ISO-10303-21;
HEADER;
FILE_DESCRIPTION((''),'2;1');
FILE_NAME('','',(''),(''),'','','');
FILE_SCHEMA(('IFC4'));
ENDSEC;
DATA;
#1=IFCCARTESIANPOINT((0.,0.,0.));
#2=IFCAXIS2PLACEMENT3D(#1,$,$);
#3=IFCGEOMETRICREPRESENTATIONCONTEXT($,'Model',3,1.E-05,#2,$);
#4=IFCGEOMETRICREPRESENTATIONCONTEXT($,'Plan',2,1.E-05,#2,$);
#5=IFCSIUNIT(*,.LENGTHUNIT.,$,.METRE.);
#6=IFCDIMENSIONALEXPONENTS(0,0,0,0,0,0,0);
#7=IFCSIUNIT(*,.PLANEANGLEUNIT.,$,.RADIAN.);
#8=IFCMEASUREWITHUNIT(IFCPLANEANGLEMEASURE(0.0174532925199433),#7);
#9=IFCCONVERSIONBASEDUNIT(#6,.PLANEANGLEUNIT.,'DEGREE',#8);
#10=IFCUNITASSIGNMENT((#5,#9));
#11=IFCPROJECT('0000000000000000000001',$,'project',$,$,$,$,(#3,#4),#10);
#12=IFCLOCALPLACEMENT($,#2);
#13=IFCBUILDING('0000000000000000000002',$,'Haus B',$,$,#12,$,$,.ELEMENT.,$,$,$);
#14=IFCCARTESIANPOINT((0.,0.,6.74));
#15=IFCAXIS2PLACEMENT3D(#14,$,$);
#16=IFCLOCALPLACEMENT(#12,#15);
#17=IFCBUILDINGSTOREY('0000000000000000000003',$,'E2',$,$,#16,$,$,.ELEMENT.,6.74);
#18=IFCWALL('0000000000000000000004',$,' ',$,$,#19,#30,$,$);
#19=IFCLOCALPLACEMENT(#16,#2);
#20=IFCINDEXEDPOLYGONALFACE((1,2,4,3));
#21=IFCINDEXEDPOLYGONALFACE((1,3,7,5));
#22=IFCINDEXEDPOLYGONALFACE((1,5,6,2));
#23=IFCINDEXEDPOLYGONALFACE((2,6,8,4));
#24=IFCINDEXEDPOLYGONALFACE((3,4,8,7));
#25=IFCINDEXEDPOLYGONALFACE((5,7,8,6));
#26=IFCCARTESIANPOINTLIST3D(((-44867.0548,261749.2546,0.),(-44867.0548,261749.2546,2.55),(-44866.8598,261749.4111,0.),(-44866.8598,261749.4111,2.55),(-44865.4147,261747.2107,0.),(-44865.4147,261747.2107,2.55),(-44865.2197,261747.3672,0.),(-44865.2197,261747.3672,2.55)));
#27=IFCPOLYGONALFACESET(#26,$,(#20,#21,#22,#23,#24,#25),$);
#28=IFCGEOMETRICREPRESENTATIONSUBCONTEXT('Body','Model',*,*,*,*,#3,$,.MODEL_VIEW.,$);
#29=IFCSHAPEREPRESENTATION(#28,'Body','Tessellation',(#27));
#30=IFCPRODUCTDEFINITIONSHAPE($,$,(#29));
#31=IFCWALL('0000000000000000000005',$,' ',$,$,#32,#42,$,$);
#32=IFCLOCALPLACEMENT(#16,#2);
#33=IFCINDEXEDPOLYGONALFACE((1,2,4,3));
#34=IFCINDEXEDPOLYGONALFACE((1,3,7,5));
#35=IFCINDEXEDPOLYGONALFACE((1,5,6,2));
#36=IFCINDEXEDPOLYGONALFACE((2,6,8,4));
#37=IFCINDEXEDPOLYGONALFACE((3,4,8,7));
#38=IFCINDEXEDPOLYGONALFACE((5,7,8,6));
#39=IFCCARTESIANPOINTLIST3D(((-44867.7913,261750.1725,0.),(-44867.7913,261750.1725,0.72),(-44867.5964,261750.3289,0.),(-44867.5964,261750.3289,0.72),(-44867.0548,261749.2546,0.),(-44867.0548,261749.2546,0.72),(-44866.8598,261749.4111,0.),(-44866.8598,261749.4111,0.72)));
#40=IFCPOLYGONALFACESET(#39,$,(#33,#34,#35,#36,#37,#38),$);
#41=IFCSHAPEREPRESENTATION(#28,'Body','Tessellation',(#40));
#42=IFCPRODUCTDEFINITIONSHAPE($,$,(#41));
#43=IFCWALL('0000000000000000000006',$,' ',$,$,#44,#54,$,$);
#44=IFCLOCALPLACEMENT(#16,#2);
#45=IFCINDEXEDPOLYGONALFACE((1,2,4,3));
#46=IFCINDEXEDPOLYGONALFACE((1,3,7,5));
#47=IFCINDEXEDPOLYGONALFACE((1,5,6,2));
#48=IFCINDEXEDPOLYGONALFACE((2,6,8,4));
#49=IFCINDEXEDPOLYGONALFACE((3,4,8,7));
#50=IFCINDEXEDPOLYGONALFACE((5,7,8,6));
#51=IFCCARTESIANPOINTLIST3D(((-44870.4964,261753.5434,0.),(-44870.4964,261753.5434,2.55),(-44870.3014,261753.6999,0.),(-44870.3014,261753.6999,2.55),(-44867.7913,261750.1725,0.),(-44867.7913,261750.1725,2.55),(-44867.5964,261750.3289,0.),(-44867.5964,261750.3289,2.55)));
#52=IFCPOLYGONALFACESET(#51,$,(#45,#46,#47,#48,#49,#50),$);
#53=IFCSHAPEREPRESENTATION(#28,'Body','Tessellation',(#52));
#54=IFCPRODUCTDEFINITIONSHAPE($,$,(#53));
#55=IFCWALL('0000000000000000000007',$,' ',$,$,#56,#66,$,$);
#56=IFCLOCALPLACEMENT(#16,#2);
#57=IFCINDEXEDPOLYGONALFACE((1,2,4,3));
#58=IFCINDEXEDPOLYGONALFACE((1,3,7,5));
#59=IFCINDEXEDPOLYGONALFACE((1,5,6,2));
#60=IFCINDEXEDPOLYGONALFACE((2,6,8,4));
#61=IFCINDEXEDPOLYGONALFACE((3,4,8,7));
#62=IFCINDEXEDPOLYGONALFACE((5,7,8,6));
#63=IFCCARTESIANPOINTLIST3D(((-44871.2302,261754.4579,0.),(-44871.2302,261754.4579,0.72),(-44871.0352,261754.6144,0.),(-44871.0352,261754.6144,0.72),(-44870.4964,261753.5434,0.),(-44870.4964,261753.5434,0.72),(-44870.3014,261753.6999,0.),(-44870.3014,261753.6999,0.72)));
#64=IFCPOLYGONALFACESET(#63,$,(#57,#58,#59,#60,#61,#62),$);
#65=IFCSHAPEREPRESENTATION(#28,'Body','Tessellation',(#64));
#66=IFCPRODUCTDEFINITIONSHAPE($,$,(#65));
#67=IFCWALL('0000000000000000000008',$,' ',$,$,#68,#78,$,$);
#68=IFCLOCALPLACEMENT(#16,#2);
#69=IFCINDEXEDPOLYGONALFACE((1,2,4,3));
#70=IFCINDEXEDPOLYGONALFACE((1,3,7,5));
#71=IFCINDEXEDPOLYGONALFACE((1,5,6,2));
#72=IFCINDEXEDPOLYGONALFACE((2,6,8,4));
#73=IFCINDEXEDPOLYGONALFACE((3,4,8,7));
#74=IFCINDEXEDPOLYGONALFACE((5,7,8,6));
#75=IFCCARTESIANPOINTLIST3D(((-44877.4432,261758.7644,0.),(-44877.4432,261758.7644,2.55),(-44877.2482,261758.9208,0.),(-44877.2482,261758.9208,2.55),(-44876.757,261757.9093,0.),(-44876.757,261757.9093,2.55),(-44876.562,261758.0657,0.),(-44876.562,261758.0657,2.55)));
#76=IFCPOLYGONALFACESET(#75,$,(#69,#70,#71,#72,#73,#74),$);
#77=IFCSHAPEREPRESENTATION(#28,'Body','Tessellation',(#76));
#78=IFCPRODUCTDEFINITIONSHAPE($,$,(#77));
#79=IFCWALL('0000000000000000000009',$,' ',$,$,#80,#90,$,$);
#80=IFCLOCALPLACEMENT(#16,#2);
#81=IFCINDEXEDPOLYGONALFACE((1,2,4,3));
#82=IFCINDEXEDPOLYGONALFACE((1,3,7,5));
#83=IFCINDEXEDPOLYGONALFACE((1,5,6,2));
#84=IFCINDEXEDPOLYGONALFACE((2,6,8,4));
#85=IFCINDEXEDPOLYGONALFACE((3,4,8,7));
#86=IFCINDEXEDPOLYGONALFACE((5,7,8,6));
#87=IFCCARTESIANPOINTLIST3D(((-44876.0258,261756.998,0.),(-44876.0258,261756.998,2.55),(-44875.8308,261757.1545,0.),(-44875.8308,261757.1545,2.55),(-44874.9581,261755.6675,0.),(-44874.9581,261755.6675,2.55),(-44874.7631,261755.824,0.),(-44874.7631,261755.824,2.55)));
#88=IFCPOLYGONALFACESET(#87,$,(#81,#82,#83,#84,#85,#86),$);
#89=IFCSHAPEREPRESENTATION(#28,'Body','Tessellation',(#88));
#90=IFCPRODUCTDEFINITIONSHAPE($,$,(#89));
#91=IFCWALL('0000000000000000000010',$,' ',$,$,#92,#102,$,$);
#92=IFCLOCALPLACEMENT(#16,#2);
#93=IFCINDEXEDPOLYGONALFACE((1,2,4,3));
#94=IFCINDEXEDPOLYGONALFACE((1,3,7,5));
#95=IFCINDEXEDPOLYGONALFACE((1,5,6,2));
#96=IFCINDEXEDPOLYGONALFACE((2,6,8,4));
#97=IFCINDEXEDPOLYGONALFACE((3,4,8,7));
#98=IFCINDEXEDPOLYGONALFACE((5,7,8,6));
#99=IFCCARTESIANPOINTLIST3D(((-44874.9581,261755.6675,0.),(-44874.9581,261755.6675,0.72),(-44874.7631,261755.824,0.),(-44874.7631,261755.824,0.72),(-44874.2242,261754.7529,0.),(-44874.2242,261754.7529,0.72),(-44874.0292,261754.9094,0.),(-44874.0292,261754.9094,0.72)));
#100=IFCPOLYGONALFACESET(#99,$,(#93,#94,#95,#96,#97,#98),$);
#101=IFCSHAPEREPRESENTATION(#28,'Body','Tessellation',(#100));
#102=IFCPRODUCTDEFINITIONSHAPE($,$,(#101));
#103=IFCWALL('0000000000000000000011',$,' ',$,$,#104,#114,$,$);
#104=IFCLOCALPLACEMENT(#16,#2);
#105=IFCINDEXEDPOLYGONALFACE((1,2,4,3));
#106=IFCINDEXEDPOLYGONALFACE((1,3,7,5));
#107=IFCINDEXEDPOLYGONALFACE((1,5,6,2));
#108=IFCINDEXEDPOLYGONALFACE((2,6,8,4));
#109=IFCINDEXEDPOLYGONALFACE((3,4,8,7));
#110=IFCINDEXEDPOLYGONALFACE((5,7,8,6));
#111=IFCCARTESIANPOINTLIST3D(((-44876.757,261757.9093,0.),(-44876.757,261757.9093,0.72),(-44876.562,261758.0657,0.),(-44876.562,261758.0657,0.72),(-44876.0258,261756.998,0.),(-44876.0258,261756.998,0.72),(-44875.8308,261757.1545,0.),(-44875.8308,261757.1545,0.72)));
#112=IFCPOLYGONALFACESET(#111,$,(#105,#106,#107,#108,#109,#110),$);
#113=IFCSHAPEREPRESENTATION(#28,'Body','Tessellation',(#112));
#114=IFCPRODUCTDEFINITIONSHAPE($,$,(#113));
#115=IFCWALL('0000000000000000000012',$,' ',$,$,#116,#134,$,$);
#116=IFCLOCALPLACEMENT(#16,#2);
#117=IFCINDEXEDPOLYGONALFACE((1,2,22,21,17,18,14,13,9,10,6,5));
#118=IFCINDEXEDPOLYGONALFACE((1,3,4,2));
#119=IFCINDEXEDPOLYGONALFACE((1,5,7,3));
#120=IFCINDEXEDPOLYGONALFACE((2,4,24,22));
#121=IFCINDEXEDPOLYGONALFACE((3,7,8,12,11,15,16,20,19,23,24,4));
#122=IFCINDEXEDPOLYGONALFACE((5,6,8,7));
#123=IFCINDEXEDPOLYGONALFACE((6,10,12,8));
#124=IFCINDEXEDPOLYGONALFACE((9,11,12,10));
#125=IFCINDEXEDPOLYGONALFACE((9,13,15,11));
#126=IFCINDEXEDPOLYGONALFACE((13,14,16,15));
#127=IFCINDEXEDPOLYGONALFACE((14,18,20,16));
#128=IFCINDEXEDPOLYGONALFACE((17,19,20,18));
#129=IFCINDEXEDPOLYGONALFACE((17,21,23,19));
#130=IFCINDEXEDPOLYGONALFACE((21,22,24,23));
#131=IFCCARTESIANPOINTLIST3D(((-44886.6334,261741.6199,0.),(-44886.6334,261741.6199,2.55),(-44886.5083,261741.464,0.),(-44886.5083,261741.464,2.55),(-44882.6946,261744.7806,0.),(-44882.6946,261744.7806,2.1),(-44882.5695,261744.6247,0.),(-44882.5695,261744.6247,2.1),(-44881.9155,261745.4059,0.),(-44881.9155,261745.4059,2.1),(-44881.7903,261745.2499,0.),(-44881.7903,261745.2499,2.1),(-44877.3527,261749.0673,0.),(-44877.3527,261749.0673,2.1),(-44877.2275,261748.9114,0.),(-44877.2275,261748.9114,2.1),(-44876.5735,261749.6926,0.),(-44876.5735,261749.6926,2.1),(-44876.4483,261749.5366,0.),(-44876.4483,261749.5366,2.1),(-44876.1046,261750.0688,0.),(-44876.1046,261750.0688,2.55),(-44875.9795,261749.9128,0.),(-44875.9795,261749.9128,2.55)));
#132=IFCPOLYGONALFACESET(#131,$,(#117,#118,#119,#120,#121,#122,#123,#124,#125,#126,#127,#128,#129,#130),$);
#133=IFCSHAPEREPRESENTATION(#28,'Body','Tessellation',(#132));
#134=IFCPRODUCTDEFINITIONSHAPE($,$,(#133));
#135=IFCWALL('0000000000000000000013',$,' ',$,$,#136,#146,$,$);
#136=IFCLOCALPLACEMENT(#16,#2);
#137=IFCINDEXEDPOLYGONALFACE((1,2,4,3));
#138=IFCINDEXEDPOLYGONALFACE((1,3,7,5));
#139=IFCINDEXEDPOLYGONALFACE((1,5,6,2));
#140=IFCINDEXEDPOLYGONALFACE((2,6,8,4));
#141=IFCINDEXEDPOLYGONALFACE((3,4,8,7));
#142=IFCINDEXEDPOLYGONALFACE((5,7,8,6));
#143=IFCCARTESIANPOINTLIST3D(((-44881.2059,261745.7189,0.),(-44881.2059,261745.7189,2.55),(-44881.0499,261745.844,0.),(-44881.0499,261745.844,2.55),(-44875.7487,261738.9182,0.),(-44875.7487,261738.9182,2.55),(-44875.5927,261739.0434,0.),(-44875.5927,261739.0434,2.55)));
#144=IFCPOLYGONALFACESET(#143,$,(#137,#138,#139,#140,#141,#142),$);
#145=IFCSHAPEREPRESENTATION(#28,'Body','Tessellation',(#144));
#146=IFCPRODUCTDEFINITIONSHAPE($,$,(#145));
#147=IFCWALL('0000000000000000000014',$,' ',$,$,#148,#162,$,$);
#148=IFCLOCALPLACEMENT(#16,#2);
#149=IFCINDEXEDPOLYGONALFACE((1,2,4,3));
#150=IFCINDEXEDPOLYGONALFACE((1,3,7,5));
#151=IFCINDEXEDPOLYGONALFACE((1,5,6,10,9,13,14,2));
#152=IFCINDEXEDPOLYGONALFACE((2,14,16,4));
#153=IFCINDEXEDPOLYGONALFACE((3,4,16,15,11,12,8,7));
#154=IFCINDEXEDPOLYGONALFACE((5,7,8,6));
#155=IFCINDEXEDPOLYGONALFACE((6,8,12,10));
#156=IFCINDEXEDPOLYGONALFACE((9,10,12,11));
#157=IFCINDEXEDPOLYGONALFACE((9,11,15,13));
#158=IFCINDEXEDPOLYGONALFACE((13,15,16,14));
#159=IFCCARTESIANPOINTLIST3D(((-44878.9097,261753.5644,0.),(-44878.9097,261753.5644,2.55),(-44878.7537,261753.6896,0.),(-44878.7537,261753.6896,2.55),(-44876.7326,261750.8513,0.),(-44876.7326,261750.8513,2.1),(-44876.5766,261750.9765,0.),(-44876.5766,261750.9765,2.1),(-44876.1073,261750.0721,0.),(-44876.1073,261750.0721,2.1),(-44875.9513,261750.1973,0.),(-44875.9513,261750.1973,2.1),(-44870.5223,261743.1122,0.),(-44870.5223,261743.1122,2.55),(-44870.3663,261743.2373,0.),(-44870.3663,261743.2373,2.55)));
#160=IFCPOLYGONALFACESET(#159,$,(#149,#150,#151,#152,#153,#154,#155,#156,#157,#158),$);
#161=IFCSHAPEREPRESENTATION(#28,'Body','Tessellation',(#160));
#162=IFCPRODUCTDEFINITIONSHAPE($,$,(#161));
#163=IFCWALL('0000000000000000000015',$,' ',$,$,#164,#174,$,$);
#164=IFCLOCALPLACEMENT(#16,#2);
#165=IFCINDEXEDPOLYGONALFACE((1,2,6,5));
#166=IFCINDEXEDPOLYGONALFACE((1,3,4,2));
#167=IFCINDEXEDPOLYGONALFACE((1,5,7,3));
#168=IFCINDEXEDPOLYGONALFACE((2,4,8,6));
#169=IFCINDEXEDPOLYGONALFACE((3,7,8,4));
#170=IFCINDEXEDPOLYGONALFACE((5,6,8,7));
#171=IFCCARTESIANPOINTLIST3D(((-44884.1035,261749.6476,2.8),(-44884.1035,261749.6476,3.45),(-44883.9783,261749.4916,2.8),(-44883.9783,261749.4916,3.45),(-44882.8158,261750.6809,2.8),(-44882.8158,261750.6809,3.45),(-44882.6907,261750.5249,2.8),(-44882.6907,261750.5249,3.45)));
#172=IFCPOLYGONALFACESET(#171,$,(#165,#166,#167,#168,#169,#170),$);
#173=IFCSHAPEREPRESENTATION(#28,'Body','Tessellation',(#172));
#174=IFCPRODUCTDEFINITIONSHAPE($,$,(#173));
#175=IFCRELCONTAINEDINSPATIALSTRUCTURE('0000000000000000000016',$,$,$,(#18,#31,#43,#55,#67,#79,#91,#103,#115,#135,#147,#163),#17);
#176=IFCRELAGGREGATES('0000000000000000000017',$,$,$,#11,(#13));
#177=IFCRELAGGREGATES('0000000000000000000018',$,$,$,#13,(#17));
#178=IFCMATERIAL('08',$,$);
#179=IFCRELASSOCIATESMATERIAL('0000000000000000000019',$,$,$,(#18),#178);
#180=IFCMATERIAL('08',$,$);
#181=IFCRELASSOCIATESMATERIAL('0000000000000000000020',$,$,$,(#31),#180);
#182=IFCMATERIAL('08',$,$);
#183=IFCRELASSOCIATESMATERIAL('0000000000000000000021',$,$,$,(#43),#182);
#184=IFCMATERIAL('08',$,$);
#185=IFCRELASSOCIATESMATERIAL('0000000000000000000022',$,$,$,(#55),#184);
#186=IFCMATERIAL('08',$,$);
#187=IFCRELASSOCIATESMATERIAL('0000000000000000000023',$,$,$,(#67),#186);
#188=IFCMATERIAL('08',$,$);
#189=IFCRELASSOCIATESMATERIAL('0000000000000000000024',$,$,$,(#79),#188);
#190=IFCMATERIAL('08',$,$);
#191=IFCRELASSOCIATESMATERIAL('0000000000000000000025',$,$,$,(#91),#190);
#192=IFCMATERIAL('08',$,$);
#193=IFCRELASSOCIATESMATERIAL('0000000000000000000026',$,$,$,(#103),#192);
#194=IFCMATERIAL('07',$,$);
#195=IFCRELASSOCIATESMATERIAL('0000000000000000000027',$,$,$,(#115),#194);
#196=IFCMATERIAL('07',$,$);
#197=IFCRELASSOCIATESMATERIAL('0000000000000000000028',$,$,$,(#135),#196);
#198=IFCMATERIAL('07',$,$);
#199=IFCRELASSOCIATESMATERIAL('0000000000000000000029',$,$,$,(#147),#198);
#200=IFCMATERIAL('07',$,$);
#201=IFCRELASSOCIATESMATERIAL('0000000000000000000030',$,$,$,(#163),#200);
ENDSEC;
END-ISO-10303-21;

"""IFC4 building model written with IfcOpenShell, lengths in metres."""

from ifc_helpers import new_model, entity, si_unit, converted_unit, frame, frame_2d, origin, origin_with_axes, place, context, subcontext, project, spatial, polyline, rectangle, outline, extrude, material, element, save


model = new_model("IFC4")

# Units and contexts
model_context = context("Model", 3, precision=1e-05, world=origin())
plan_context = context("Plan", 2, precision=1e-05, world=origin())
body_context = subcontext(model_context, "Body", "Model", "MODEL_VIEW")
ifc_project = project(units=[si_unit("LENGTHUNIT", "METRE"), converted_unit("PLANEANGLEUNIT", "DEGREE", entity("IfcPlaneAngleMeasure", 0.0174532925199433), si_unit("PLANEANGLEUNIT", "RADIAN"), dimensions=[0, 0, 0, 0, 0, 0, 0])], contexts=[model_context, plan_context])

# Building, storey
building_placement = place(None, origin())
building = spatial("IfcBuilding", under=ifc_project, at=building_placement, Name="Haus B", CompositionType="ELEMENT")
storey_placement = place(building_placement, frame((0.0, 0.0, 6.74)))
storey = spatial("IfcBuildingStorey", under=building, at=storey_placement, Name="E2", CompositionType="ELEMENT", Elevation=6.74)

# Walls
ifc_material_1 = material(Name="08")
wall_1_placement = place(storey_placement, frame((-44867.0548, 261749.2546, 0.0), z_axis=(0.0, 0.0, 1.0), x_axis=(0.625861, -0.779935, 0.0)))
element("IfcWall", 1, at=wall_1_placement, inside=storey, material=ifc_material_1, Name=" ", context=body_context, shape_type="SweptSolid", body=[
    extrude(rectangle(XDim=2.6206, YDim=0.25, at=frame_2d((1.3103, 0.125), x_axis=(1.0, 0.0))), origin_with_axes(), (0.0, 0.0, 1.0), 2.55),
])
ifc_material_2 = material(Name="08")
wall_2_placement = place(storey_placement, frame((-44867.7913, 261750.1725, 0.0), z_axis=(0.0, 0.0, 1.0), x_axis=(0.625861, -0.779935, 0.0)))
element("IfcWall", 2, at=wall_2_placement, inside=storey, material=ifc_material_2, Name=" ", context=body_context, shape_type="SweptSolid", body=[
    extrude(rectangle(XDim=1.1768, YDim=0.25, at=frame_2d((0.5884, 0.125), x_axis=(1.0, 0.0))), origin_with_axes(), (0.0, 0.0, 1.0), 0.72),
])
ifc_material_3 = material(Name="08")
wall_3_placement = place(storey_placement, frame((-44870.4964, 261753.5434, 0.0), z_axis=(0.0, 0.0, 1.0), x_axis=(0.625861, -0.779935, 0.0)))
element("IfcWall", 3, at=wall_3_placement, inside=storey, material=ifc_material_3, Name=" ", context=body_context, shape_type="SweptSolid", body=[
    extrude(rectangle(XDim=4.3221, YDim=0.25, at=frame_2d((2.161, 0.125), x_axis=(1.0, 0.0))), origin_with_axes(), (0.0, 0.0, 1.0), 2.55),
])
ifc_material_4 = material(Name="08")
wall_4_placement = place(storey_placement, frame((-44871.2302, 261754.4579, 0.0), z_axis=(0.0, 0.0, 1.0), x_axis=(0.625861, -0.779935, 0.0)))
element("IfcWall", 4, at=wall_4_placement, inside=storey, material=ifc_material_4, Name=" ", context=body_context, shape_type="SweptSolid", body=[
    extrude(rectangle(XDim=1.1726, YDim=0.25, at=frame_2d((0.5863, 0.125), x_axis=(1.0, 0.0))), origin_with_axes(), (0.0, 0.0, 1.0), 0.72),
])
ifc_material_5 = material(Name="08")
wall_5_placement = place(storey_placement, frame((-44877.4432, 261758.7644, 0.0), z_axis=(0.0, 0.0, 1.0), x_axis=(0.625861, -0.779935, 0.0)))
element("IfcWall", 5, at=wall_5_placement, inside=storey, material=ifc_material_5, Name=" ", context=body_context, shape_type="SweptSolid", body=[
    extrude(rectangle(XDim=1.0964, YDim=0.25, at=frame_2d((0.5482, 0.125), x_axis=(1.0, 0.0))), origin_with_axes(), (0.0, 0.0, 1.0), 2.55),
])
ifc_material_6 = material(Name="08")
wall_6_placement = place(storey_placement, frame((-44876.0258, 261756.998, 0.0), z_axis=(0.0, 0.0, 1.0), x_axis=(0.625861, -0.779935, 0.0)))
element("IfcWall", 6, at=wall_6_placement, inside=storey, material=ifc_material_6, Name=" ", context=body_context, shape_type="SweptSolid", body=[
    extrude(rectangle(XDim=1.706, YDim=0.25, at=frame_2d((0.853, 0.125), x_axis=(1.0, 0.0))), origin_with_axes(), (0.0, 0.0, 1.0), 2.55),
])
ifc_material_7 = material(Name="08")
wall_7_placement = place(storey_placement, frame((-44874.9581, 261755.6675, 0.0), z_axis=(0.0, 0.0, 1.0), x_axis=(0.625861, -0.779935, 0.0)))
element("IfcWall", 7, at=wall_7_placement, inside=storey, material=ifc_material_7, Name=" ", context=body_context, shape_type="SweptSolid", body=[
    extrude(rectangle(XDim=1.1726, YDim=0.25, at=frame_2d((0.5863, 0.125), x_axis=(1.0, 0.0))), origin_with_axes(), (0.0, 0.0, 1.0), 0.72),
])
ifc_material_8 = material(Name="08")
wall_8_placement = place(storey_placement, frame((-44876.757, 261757.9093, 0.0), z_axis=(0.0, 0.0, 1.0), x_axis=(0.625861, -0.779935, 0.0)))
element("IfcWall", 8, at=wall_8_placement, inside=storey, material=ifc_material_8, Name=" ", context=body_context, shape_type="SweptSolid", body=[
    extrude(rectangle(XDim=1.1684, YDim=0.25, at=frame_2d((0.5842, 0.125), x_axis=(1.0, 0.0))), origin_with_axes(), (0.0, 0.0, 1.0), 0.72),
])

# Wall, openings
ifc_material_9 = material(Name="07")
wall_9_placement = place(storey_placement, frame((-44876.1046, 261750.0688, 0.0), z_axis=(0.0, 0.0, 1.0), x_axis=(-0.779935, -0.625861, 0.0)))
wall_9 = element("IfcWall", 9, at=wall_9_placement, inside=storey, material=ifc_material_9, Name=" ", context=body_context, shape_type="SweptSolid", body=[
    extrude(rectangle(XDim=13.4996, YDim=0.2, at=frame_2d((6.7498, 0.1), x_axis=(1.0, 0.0))), origin_with_axes(), (0.0, 0.0, 1.0), 2.55),
])
opening_1_placement = place(wall_9_placement, frame((1.6001, 0.2, 0.0), z_axis=(0.0, -1.0, 0.0), x_axis=(0.0, 0.0, 1.0)))
element("IfcOpeningElement", 10, at=opening_1_placement, cuts=wall_9, ObjectType="Opening", context=body_context, shape_type="SweptSolid", body=[
    extrude(outline(polyline([(0.0, 0.999), (0.0, 0.0), (2.1, 0.0), (2.1, 0.999), (0.0, 0.999)])), origin_with_axes(), (0.0, 0.0, 1.0), 0.2),
])
opening_2_placement = place(wall_9_placement, frame((8.4494, 0.2, 0.0), z_axis=(0.0, -1.0, 0.0), x_axis=(0.0, 0.0, 1.0)))
element("IfcOpeningElement", 11, at=opening_2_placement, cuts=wall_9, ObjectType="Opening", context=body_context, shape_type="SweptSolid", body=[
    extrude(outline(polyline([(0.0, 0.999), (0.0, 0.0), (2.1, 0.0), (2.1, 0.999), (0.0, 0.999)])), origin_with_axes(), (0.0, 0.0, 1.0), 0.2),
])

# Wall
ifc_material_10 = material(Name="07")
wall_10_placement = place(storey_placement, frame((-44881.2059, 261745.7189, 0.0), z_axis=(0.0, 0.0, 1.0), x_axis=(0.625861, -0.779935, 0.0)))
element("IfcWall", 12, at=wall_10_placement, inside=storey, material=ifc_material_10, Name=" ", context=body_context, shape_type="SweptSolid", body=[
    extrude(rectangle(XDim=8.7195, YDim=0.2, at=frame_2d((4.3598, 0.1), x_axis=(1.0, 0.0))), origin_with_axes(), (0.0, 0.0, 1.0), 2.55),
])

# Wall, opening
ifc_material_11 = material(Name="07")
wall_11_placement = place(storey_placement, frame((-44878.9097, 261753.5644, 0.0), z_axis=(0.0, 0.0, 1.0), x_axis=(0.625861, -0.779935, 0.0)))
wall_11 = element("IfcWall", 13, at=wall_11_placement, inside=storey, material=ifc_material_11, Name=" ", context=body_context, shape_type="SweptSolid", body=[
    extrude(rectangle(XDim=13.4014, YDim=0.2, at=frame_2d((6.7007, 0.1), x_axis=(1.0, 0.0))), origin_with_axes(), (0.0, 0.0, 1.0), 2.55),
])
opening_3_placement = place(wall_11_placement, frame((4.4777, 0.2, 0.0), z_axis=(0.0, -1.0, 0.0), x_axis=(0.0, 0.0, 1.0)))
element("IfcOpeningElement", 14, at=opening_3_placement, cuts=wall_11, ObjectType="Opening", context=body_context, shape_type="SweptSolid", body=[
    extrude(outline(polyline([(0.0, 0.999), (2.1, 0.999), (2.1, 0.0), (0.0, 0.0), (0.0, 0.999)])), origin_with_axes(), (0.0, 0.0, 1.0), 0.2),
])

# Wall
ifc_material_12 = material(Name="07")
wall_12_placement = place(storey_placement, frame((-44882.8158, 261750.6809, 2.8), z_axis=(0.0, 0.0, 1.0), x_axis=(-0.779935, -0.625861, 0.0)))
element("IfcWall", 15, at=wall_12_placement, inside=storey, material=ifc_material_12, Name=" ", context=body_context, shape_type="SweptSolid", body=[
    extrude(rectangle(XDim=1.6509, YDim=0.2, at=frame_2d((0.8255, 0.1), x_axis=(1.0, 0.0))), origin_with_axes(), (0.0, 0.0, 1.0), 0.65),
])

save(model, "model.ifc")
